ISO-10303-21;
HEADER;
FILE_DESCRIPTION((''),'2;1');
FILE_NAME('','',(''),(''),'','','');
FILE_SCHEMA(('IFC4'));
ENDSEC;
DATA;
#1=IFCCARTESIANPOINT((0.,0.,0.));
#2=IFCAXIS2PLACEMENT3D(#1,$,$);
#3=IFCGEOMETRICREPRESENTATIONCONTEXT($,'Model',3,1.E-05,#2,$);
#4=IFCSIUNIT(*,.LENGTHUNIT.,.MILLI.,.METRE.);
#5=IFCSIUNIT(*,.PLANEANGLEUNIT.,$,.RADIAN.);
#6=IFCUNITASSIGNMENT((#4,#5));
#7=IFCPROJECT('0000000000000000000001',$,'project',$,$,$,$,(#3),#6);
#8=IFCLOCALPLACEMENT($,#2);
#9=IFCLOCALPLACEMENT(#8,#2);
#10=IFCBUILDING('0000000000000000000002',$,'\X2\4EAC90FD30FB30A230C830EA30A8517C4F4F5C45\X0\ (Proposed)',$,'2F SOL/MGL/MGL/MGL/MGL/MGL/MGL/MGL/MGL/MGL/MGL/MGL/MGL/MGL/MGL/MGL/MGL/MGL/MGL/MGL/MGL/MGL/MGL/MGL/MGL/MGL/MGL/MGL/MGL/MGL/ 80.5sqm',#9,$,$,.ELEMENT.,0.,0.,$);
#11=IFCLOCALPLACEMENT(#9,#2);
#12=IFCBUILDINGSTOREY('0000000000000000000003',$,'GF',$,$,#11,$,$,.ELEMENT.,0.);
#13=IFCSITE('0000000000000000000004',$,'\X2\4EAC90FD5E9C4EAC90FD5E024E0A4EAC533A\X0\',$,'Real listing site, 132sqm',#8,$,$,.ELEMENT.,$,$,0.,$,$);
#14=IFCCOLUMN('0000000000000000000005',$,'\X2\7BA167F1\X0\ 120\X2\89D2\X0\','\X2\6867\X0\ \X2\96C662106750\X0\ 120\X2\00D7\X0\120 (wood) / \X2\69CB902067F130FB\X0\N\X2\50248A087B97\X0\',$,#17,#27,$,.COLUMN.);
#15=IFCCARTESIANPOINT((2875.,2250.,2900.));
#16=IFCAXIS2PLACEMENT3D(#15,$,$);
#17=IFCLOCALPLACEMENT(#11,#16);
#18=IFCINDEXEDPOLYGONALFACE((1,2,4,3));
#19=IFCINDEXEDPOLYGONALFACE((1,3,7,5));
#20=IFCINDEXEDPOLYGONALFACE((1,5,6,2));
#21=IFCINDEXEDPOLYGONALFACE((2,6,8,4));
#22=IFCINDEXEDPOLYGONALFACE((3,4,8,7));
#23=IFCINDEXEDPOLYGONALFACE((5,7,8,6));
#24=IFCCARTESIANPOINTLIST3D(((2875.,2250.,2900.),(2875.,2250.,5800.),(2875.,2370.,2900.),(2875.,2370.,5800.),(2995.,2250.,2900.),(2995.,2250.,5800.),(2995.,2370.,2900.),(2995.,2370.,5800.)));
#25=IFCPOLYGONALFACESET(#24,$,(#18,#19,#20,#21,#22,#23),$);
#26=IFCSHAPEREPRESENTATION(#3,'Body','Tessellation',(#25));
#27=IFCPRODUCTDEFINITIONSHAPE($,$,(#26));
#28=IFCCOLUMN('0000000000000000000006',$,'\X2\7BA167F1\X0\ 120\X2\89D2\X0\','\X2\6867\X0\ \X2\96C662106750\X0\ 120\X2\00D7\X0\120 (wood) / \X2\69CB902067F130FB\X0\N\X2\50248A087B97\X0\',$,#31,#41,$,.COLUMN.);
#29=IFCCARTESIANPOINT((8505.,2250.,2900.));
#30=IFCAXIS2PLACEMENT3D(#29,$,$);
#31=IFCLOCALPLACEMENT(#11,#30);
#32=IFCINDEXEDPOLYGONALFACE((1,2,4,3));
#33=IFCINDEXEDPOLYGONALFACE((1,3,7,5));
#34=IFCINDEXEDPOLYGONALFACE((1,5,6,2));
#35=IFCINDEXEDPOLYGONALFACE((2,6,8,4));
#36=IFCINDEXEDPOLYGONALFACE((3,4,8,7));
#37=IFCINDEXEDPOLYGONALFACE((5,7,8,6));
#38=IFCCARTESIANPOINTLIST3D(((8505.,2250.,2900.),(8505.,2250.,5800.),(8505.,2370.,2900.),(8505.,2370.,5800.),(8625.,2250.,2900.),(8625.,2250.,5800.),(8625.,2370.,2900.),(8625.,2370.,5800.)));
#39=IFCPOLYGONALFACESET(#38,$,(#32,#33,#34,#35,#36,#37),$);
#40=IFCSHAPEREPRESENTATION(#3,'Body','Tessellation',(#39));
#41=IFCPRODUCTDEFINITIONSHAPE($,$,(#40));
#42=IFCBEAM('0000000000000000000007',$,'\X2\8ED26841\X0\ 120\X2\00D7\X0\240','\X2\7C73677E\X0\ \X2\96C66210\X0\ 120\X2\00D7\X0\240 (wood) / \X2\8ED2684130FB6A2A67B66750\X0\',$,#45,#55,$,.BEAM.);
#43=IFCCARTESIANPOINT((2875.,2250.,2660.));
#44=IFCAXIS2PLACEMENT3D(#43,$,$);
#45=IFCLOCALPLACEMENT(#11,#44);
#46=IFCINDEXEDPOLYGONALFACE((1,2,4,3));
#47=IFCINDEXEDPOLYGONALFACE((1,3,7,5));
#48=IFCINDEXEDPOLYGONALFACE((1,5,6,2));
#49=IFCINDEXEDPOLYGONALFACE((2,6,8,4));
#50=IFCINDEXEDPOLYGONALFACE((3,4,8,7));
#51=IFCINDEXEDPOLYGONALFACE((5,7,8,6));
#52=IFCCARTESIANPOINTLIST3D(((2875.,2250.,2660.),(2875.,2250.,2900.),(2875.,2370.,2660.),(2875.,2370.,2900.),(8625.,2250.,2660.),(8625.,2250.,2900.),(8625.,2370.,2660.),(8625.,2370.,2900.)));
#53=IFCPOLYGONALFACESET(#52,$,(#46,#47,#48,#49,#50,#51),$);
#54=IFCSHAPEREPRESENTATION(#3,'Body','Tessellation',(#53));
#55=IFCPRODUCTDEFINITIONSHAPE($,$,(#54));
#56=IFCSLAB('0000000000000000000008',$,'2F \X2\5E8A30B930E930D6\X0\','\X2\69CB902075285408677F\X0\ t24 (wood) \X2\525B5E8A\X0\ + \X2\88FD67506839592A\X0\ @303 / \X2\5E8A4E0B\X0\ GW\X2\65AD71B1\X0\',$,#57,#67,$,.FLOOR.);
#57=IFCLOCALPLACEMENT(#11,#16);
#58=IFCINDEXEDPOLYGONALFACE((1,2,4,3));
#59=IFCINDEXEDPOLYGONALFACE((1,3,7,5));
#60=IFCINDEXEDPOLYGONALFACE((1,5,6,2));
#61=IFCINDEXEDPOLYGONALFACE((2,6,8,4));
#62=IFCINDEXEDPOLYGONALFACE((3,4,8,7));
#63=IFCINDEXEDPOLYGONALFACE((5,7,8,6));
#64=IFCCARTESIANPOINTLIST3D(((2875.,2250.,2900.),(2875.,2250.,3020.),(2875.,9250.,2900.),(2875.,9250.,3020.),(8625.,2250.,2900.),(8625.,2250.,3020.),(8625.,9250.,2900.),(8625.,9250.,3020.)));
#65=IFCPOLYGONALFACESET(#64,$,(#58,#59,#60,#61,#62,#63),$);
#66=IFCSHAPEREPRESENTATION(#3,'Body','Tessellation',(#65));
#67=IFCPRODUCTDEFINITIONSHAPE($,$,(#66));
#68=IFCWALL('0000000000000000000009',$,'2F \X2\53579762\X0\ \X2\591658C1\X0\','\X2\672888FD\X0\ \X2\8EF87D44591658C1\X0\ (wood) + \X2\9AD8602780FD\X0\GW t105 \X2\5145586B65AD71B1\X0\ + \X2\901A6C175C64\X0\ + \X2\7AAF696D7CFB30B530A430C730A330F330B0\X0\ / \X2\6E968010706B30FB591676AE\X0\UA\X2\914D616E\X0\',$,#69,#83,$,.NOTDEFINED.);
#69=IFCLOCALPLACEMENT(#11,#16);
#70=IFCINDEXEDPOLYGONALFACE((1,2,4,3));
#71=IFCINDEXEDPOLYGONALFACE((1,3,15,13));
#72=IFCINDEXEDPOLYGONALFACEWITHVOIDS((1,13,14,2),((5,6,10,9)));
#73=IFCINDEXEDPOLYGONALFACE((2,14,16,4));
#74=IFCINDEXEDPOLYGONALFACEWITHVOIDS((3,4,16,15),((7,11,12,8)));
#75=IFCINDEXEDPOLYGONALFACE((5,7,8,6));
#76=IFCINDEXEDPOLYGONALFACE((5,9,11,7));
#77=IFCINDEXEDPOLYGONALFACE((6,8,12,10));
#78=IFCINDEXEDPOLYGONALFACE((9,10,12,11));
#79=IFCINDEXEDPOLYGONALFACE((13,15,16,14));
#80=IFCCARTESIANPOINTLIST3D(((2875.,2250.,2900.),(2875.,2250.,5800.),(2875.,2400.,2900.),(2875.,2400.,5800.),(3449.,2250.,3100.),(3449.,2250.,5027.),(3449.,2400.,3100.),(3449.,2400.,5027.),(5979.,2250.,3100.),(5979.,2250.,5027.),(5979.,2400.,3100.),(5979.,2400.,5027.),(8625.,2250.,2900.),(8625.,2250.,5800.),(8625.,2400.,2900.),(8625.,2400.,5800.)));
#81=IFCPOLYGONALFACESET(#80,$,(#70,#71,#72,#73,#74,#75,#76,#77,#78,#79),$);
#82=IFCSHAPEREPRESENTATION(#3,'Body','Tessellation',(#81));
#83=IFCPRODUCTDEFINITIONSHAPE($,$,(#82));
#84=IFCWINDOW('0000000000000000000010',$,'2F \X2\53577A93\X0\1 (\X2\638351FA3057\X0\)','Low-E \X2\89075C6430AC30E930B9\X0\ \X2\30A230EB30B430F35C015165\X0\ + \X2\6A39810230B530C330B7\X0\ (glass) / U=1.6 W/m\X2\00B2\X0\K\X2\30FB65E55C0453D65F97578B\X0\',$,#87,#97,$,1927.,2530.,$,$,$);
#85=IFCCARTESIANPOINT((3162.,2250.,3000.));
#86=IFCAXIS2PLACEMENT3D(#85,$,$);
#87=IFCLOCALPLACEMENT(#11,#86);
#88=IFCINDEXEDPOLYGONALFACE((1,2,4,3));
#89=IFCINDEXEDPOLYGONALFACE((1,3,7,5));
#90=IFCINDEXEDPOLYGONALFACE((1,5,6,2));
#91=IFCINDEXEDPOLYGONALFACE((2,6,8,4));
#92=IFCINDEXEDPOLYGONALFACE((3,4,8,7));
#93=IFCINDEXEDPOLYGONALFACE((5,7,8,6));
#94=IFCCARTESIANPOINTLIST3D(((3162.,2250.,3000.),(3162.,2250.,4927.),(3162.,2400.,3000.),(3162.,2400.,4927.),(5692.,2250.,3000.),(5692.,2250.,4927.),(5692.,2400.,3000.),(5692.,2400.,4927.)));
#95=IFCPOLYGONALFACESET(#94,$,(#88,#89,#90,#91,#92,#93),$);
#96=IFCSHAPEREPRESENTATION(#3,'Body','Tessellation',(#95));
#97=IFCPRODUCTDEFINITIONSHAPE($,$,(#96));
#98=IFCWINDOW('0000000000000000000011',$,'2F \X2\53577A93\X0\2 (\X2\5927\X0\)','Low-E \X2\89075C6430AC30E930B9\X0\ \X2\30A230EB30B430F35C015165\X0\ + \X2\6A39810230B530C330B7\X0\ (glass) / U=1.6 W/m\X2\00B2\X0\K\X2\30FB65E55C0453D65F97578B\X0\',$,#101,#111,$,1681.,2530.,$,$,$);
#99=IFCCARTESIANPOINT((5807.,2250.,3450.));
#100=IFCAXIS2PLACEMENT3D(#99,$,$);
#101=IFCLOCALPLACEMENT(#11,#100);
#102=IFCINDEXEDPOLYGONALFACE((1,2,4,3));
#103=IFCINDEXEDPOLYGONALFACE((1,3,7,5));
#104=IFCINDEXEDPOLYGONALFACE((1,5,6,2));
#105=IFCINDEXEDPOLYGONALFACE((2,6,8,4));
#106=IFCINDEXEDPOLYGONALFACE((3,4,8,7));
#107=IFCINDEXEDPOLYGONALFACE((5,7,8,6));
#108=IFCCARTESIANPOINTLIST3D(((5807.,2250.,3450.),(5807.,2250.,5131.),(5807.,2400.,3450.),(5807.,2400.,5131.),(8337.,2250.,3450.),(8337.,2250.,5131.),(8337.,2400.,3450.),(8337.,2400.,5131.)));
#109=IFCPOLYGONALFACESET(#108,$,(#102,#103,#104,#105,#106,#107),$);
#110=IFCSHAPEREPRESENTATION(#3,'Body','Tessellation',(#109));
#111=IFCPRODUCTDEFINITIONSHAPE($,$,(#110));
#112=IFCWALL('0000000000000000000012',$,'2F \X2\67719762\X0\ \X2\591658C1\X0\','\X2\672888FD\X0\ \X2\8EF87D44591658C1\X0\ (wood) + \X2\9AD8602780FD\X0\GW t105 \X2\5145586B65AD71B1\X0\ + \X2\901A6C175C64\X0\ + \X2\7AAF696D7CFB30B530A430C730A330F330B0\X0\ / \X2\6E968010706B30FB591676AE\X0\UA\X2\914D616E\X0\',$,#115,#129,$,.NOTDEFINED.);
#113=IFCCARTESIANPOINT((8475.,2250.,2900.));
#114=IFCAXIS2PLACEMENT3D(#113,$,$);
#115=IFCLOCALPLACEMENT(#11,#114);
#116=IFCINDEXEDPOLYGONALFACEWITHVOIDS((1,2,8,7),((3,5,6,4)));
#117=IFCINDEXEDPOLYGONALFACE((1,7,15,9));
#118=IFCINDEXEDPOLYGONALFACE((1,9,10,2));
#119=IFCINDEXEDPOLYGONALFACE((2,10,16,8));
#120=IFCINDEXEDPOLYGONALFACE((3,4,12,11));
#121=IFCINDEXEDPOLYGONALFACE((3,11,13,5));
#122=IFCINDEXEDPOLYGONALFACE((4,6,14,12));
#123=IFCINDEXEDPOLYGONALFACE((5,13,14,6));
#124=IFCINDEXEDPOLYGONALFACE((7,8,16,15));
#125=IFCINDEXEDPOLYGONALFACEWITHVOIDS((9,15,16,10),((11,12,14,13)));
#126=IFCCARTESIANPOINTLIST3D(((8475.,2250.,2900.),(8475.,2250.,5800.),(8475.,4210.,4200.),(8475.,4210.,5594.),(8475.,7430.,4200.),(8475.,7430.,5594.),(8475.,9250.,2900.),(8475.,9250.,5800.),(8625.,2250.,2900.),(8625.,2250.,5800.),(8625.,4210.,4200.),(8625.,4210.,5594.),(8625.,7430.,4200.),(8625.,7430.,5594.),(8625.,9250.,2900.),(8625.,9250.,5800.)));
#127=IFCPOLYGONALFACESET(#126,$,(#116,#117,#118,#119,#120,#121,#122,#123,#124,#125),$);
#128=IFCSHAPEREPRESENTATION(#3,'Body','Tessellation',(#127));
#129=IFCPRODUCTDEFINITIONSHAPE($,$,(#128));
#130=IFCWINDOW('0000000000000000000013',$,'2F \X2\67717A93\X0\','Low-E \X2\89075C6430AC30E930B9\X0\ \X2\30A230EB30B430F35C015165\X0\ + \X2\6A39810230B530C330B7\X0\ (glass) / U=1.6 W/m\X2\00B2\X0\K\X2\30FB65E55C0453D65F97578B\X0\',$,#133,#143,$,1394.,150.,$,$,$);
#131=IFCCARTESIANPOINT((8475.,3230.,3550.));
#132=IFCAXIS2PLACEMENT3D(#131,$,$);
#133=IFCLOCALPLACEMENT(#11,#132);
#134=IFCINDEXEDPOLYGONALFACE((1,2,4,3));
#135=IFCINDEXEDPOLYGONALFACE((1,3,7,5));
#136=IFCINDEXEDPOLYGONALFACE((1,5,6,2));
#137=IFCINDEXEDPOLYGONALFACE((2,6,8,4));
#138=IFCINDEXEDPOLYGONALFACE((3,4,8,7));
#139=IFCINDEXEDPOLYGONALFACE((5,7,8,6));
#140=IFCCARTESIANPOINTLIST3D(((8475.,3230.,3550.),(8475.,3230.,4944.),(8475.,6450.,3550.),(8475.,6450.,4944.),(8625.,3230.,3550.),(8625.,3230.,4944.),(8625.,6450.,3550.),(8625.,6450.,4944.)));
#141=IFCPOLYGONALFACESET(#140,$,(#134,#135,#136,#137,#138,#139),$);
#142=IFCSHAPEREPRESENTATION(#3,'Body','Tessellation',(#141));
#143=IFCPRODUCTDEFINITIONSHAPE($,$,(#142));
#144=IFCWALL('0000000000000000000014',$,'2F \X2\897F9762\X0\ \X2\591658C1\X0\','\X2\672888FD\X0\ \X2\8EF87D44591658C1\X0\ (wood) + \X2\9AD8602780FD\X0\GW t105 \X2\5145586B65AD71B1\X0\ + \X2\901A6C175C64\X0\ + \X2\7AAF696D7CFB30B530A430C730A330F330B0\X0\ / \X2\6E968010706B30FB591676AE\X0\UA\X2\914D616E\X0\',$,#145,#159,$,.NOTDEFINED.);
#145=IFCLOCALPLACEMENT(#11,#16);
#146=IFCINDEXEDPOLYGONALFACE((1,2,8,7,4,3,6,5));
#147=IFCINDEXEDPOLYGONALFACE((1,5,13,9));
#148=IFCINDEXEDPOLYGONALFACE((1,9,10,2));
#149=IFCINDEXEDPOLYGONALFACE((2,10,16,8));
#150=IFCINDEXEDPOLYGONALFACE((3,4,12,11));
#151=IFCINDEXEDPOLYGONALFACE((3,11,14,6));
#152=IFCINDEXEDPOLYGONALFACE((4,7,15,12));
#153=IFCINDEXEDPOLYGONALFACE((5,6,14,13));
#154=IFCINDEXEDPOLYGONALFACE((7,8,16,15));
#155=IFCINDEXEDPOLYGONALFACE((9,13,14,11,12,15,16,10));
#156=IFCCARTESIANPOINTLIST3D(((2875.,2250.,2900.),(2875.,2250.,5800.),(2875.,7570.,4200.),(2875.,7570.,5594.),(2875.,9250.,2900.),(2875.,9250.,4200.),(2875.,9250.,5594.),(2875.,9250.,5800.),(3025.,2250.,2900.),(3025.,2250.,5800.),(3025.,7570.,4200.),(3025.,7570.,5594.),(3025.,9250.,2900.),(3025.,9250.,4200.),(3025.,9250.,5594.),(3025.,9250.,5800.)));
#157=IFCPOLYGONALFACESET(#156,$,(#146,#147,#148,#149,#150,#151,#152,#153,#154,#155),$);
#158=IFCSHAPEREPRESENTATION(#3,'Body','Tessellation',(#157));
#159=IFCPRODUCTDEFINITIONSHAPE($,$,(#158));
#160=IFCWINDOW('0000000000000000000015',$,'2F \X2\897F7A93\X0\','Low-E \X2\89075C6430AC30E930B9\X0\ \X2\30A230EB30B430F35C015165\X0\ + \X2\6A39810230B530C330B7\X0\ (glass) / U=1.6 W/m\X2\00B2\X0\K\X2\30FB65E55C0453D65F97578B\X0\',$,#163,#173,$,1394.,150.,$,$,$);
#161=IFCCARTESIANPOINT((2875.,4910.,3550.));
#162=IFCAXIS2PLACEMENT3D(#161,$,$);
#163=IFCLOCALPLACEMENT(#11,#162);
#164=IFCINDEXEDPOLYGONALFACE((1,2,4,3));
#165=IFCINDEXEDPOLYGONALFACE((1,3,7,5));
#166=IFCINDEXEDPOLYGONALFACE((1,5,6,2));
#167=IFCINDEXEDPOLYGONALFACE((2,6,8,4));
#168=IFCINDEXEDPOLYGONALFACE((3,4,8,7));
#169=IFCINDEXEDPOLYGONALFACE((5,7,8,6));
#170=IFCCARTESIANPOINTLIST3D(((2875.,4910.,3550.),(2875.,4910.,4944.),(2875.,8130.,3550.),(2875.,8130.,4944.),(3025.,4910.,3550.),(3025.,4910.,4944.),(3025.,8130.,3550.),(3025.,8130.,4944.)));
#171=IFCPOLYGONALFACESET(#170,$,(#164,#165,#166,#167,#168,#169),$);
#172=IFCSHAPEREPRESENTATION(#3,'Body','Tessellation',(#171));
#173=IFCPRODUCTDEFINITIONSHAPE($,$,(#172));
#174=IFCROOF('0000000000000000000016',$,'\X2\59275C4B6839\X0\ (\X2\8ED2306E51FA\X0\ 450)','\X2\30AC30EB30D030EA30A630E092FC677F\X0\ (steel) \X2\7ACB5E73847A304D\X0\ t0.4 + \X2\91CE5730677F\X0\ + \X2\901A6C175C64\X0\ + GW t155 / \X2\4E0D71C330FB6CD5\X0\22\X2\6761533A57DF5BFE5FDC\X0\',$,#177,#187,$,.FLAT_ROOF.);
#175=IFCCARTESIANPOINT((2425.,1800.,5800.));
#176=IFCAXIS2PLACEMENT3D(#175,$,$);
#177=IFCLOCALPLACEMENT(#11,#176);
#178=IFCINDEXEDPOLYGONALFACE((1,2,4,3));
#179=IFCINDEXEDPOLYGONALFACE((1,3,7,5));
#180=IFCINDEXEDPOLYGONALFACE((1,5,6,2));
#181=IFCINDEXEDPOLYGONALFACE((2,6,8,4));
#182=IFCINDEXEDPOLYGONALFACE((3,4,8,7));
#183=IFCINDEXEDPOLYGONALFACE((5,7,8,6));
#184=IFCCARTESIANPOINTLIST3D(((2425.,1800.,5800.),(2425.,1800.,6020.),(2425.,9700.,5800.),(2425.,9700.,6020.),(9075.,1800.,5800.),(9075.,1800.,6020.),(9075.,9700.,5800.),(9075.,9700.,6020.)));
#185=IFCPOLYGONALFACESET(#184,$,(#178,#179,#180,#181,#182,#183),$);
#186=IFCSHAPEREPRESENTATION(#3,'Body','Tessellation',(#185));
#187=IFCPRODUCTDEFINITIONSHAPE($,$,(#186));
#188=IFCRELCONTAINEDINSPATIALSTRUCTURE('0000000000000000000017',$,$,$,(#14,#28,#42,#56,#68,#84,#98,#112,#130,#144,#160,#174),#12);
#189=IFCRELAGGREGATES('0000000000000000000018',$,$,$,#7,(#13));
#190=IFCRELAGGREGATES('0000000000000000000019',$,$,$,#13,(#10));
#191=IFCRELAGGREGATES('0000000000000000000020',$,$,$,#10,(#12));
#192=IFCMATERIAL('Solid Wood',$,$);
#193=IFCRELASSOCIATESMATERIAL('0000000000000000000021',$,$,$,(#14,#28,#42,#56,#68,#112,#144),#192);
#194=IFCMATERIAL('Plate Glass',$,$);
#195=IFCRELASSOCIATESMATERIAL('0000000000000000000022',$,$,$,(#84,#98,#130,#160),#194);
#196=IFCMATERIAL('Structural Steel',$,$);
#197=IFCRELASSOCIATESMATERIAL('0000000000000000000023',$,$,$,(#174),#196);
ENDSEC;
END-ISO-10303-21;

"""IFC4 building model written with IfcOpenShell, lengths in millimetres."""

from ifc_helpers import new_model, si_unit, frame, frame_2d, origin, place, context, project, spatial, rectangle, extrude, material, element, fill, save


model = new_model("IFC4")

# Units and contexts
model_context = context("Model", 3, precision=1e-05, world=origin())
ifc_project = project(units=[si_unit("LENGTHUNIT", "METRE", prefix="MILLI"), si_unit("PLANEANGLEUNIT", "RADIAN")], contexts=[model_context])

# Site, building, storey
site_placement = place(None, origin())
site = spatial("IfcSite", under=ifc_project, at=site_placement, Name="京都府京都市上京区", ObjectType="Real listing site, 132sqm", CompositionType="ELEMENT", RefElevation=0.0)
building_placement = place(site_placement, origin())
building = spatial("IfcBuilding", under=site, at=building_placement, Name="京都・アトリエ兼住居 (Proposed)", ObjectType="2F SOL/MGL/MGL/MGL/MGL/MGL/MGL/MGL/MGL/MGL/MGL/MGL/MGL/MGL/MGL/MGL/MGL/MGL/MGL/MGL/MGL/MGL/MGL/MGL/MGL/MGL/MGL/MGL/MGL/MGL/ 80.5sqm", CompositionType="ELEMENT", ElevationOfRefHeight=0.0, ElevationOfTerrain=0.0)
storey_placement = place(building_placement, origin())
storey = spatial("IfcBuildingStorey", under=building, at=storey_placement, Name="GF", CompositionType="ELEMENT", Elevation=0.0)

# Columns
ifc_material_1 = material(Name="Solid Wood")
column_1_placement = place(storey_placement, frame((2875.0, 2250.0, 2900.0)))
element("IfcColumn", 1, at=column_1_placement, inside=storey, material=ifc_material_1, Name="管柱 120角", Description="桧 集成材 120×120 (wood) / 構造柱・N値計算", PredefinedType="COLUMN", context=model_context, shape_type="SweptSolid", body=[
    extrude(rectangle(XDim=120.0, YDim=120.0, at=frame_2d((60.0, 60.0))), frame((2875.0, 2250.0, 2900.0)), (0.0, 0.0, 1.0), 2900.0),
])
column_2_placement = place(storey_placement, frame((8505.0, 2250.0, 2900.0)))
element("IfcColumn", 2, at=column_2_placement, inside=storey, material=ifc_material_1, Name="管柱 120角", Description="桧 集成材 120×120 (wood) / 構造柱・N値計算", PredefinedType="COLUMN", context=model_context, shape_type="SweptSolid", body=[
    extrude(rectangle(XDim=120.0, YDim=120.0, at=frame_2d((60.0, 60.0))), frame((8505.0, 2250.0, 2900.0)), (0.0, 0.0, 1.0), 2900.0),
])

# Beam
beam_1_placement = place(storey_placement, frame((2875.0, 2250.0, 2660.0)))
element("IfcBeam", 3, at=beam_1_placement, inside=storey, material=ifc_material_1, Name="軒桁 120×240", Description="米松 集成 120×240 (wood) / 軒桁・横架材", PredefinedType="BEAM", context=model_context, shape_type="SweptSolid", body=[
    extrude(rectangle(XDim=5750.0, YDim=120.0, at=frame_2d((2875.0, 60.0))), frame((2875.0, 2250.0, 2660.0)), (0.0, 0.0, 1.0), 240.0),
])

# Slab
slab_placement = place(storey_placement, frame((2875.0, 2250.0, 2900.0)))
element("IfcSlab", 4, at=slab_placement, inside=storey, material=ifc_material_1, Name="2F 床スラブ", Description="構造用合板 t24 (wood) 剛床 + 製材根太 @303 / 床下 GW断熱", PredefinedType="FLOOR", context=model_context, shape_type="SweptSolid", body=[
    extrude(rectangle(XDim=5750.0, YDim=7000.0, at=frame_2d((2875.0, 3500.0))), frame((2875.0, 2250.0, 2900.0)), (0.0, 0.0, 1.0), 120.0),
])

# Wall, openings, windows
wall_1_placement = place(storey_placement, frame((2875.0, 2250.0, 2900.0)))
wall_1 = element("IfcWall", 5, at=wall_1_placement, inside=storey, material=ifc_material_1, Name="2F 南面 外壁", Description="木製 軸組外壁 (wood) + 高性能GW t105 充填断熱 + 通気層 + 窯業系サイディング / 準耐火・外皮UA配慮", PredefinedType="NOTDEFINED", context=model_context, shape_type="SweptSolid", body=[
    extrude(rectangle(XDim=5750.0, YDim=150.0, at=frame_2d((2875.0, 75.0))), frame((2875.0, 2250.0, 2900.0)), (0.0, 0.0, 1.0), 2900.0),
])
opening_1_placement = place(storey_placement, frame((3162.0, 2250.0, 3000.0)))
opening_1 = element("IfcOpeningElement", 6, at=opening_1_placement, cuts=wall_1, PredefinedType="NOTDEFINED", context=model_context, shape_type="SweptSolid", body=[
    extrude(rectangle(XDim=2530.0, YDim=150.0, at=frame_2d((1265.0, 75.0))), frame((3162.0, 2250.0, 3000.0)), (0.0, 0.0, 1.0), 1927.0),
])
opening_2_placement = place(storey_placement, frame((5807.0, 2250.0, 3450.0)))
opening_2 = element("IfcOpeningElement", 7, at=opening_2_placement, cuts=wall_1, PredefinedType="NOTDEFINED", context=model_context, shape_type="SweptSolid", body=[
    extrude(rectangle(XDim=2530.0, YDim=150.0, at=frame_2d((1265.0, 75.0))), frame((5807.0, 2250.0, 3450.0)), (0.0, 0.0, 1.0), 1681.0),
])
ifc_material_2 = material(Name="Plate Glass")
window_1_placement = place(storey_placement, frame((3162.0, 2250.0, 3000.0)))
window_1 = element("IfcWindow", 8, at=window_1_placement, inside=storey, material=ifc_material_2, Name="2F 南窓1 (掃出し)", Description="Low-E 複層ガラス アルゴン封入 + 樹脂サッシ (glass) / U=1.6 W/m²K・日射取得型", OverallHeight=1927.0, OverallWidth=2530.0, context=model_context, shape_type="SweptSolid", body=[
    extrude(rectangle(XDim=2530.0, YDim=150.0, at=frame_2d((1265.0, 75.0))), frame((3162.0, 2250.0, 3000.0)), (0.0, 0.0, 1.0), 1927.0),
])
fill(opening_1, window_1)
window_2_placement = place(storey_placement, frame((5807.0, 2250.0, 3450.0)))
window_2 = element("IfcWindow", 9, at=window_2_placement, inside=storey, material=ifc_material_2, Name="2F 南窓2 (大)", Description="Low-E 複層ガラス アルゴン封入 + 樹脂サッシ (glass) / U=1.6 W/m²K・日射取得型", OverallHeight=1681.0, OverallWidth=2530.0, context=model_context, shape_type="SweptSolid", body=[
    extrude(rectangle(XDim=2530.0, YDim=150.0, at=frame_2d((1265.0, 75.0))), frame((5807.0, 2250.0, 3450.0)), (0.0, 0.0, 1.0), 1681.0),
])
fill(opening_2, window_2)

# Walls, openings, windows
wall_2_placement = place(storey_placement, frame((8475.0, 2250.0, 2900.0)))
wall_2 = element("IfcWall", 10, at=wall_2_placement, inside=storey, material=ifc_material_1, Name="2F 東面 外壁", Description="木製 軸組外壁 (wood) + 高性能GW t105 充填断熱 + 通気層 + 窯業系サイディング / 準耐火・外皮UA配慮", PredefinedType="NOTDEFINED", context=model_context, shape_type="SweptSolid", body=[
    extrude(rectangle(XDim=150.0, YDim=7000.0, at=frame_2d((75.0, 3500.0))), frame((8475.0, 2250.0, 2900.0)), (0.0, 0.0, 1.0), 2900.0),
])
opening_3_placement = place(storey_placement, frame((8475.0, 3230.0, 3550.0)))
opening_3 = element("IfcOpeningElement", 11, at=opening_3_placement, cuts=wall_2, PredefinedType="NOTDEFINED", context=model_context, shape_type="SweptSolid", body=[
    extrude(rectangle(XDim=150.0, YDim=3220.0, at=frame_2d((75.0, 1610.0))), frame((8475.0, 3230.0, 3550.0)), (0.0, 0.0, 1.0), 1394.0),
])
window_3_placement = place(storey_placement, frame((8475.0, 3230.0, 3550.0)))
window_3 = element("IfcWindow", 12, at=window_3_placement, inside=storey, material=ifc_material_2, Name="2F 東窓", Description="Low-E 複層ガラス アルゴン封入 + 樹脂サッシ (glass) / U=1.6 W/m²K・日射取得型", OverallHeight=1394.0, OverallWidth=150.0, context=model_context, shape_type="SweptSolid", body=[
    extrude(rectangle(XDim=150.0, YDim=3220.0, at=frame_2d((75.0, 1610.0))), frame((8475.0, 3230.0, 3550.0)), (0.0, 0.0, 1.0), 1394.0),
])
fill(opening_3, window_3)
wall_3_placement = place(storey_placement, frame((2875.0, 2250.0, 2900.0)))
wall_3 = element("IfcWall", 13, at=wall_3_placement, inside=storey, material=ifc_material_1, Name="2F 西面 外壁", Description="木製 軸組外壁 (wood) + 高性能GW t105 充填断熱 + 通気層 + 窯業系サイディング / 準耐火・外皮UA配慮", PredefinedType="NOTDEFINED", context=model_context, shape_type="SweptSolid", body=[
    extrude(rectangle(XDim=150.0, YDim=7000.0, at=frame_2d((75.0, 3500.0))), frame((2875.0, 2250.0, 2900.0)), (0.0, 0.0, 1.0), 2900.0),
])
opening_4_placement = place(storey_placement, frame((2875.0, 4910.0, 3550.0)))
opening_4 = element("IfcOpeningElement", 14, at=opening_4_placement, cuts=wall_3, PredefinedType="NOTDEFINED", context=model_context, shape_type="SweptSolid", body=[
    extrude(rectangle(XDim=150.0, YDim=3220.0, at=frame_2d((75.0, 1610.0))), frame((2875.0, 4910.0, 3550.0)), (0.0, 0.0, 1.0), 1394.0),
])
window_4_placement = place(storey_placement, frame((2875.0, 4910.0, 3550.0)))
window_4 = element("IfcWindow", 15, at=window_4_placement, inside=storey, material=ifc_material_2, Name="2F 西窓", Description="Low-E 複層ガラス アルゴン封入 + 樹脂サッシ (glass) / U=1.6 W/m²K・日射取得型", OverallHeight=1394.0, OverallWidth=150.0, context=model_context, shape_type="SweptSolid", body=[
    extrude(rectangle(XDim=150.0, YDim=3220.0, at=frame_2d((75.0, 1610.0))), frame((2875.0, 4910.0, 3550.0)), (0.0, 0.0, 1.0), 1394.0),
])
fill(opening_4, window_4)

# Roof
ifc_material_3 = material(Name="Structural Steel")
roof_placement = place(storey_placement, frame((2425.0, 1800.0, 5800.0)))
element("IfcRoof", 16, at=roof_placement, inside=storey, material=ifc_material_3, Name="大屋根 (軒の出 450)", Description="ガルバリウム鋼板 (steel) 立平葺き t0.4 + 野地板 + 通気層 + GW t155 / 不燃・法22条区域対応", PredefinedType="FLAT_ROOF", context=model_context, shape_type="SweptSolid", body=[
    extrude(rectangle(XDim=6650.0, YDim=7900.0, at=frame_2d((3325.0, 3950.0))), frame((2425.0, 1800.0, 5800.0)), (0.0, 0.0, 1.0), 220.0),
])

save(model, "model.ifc")
